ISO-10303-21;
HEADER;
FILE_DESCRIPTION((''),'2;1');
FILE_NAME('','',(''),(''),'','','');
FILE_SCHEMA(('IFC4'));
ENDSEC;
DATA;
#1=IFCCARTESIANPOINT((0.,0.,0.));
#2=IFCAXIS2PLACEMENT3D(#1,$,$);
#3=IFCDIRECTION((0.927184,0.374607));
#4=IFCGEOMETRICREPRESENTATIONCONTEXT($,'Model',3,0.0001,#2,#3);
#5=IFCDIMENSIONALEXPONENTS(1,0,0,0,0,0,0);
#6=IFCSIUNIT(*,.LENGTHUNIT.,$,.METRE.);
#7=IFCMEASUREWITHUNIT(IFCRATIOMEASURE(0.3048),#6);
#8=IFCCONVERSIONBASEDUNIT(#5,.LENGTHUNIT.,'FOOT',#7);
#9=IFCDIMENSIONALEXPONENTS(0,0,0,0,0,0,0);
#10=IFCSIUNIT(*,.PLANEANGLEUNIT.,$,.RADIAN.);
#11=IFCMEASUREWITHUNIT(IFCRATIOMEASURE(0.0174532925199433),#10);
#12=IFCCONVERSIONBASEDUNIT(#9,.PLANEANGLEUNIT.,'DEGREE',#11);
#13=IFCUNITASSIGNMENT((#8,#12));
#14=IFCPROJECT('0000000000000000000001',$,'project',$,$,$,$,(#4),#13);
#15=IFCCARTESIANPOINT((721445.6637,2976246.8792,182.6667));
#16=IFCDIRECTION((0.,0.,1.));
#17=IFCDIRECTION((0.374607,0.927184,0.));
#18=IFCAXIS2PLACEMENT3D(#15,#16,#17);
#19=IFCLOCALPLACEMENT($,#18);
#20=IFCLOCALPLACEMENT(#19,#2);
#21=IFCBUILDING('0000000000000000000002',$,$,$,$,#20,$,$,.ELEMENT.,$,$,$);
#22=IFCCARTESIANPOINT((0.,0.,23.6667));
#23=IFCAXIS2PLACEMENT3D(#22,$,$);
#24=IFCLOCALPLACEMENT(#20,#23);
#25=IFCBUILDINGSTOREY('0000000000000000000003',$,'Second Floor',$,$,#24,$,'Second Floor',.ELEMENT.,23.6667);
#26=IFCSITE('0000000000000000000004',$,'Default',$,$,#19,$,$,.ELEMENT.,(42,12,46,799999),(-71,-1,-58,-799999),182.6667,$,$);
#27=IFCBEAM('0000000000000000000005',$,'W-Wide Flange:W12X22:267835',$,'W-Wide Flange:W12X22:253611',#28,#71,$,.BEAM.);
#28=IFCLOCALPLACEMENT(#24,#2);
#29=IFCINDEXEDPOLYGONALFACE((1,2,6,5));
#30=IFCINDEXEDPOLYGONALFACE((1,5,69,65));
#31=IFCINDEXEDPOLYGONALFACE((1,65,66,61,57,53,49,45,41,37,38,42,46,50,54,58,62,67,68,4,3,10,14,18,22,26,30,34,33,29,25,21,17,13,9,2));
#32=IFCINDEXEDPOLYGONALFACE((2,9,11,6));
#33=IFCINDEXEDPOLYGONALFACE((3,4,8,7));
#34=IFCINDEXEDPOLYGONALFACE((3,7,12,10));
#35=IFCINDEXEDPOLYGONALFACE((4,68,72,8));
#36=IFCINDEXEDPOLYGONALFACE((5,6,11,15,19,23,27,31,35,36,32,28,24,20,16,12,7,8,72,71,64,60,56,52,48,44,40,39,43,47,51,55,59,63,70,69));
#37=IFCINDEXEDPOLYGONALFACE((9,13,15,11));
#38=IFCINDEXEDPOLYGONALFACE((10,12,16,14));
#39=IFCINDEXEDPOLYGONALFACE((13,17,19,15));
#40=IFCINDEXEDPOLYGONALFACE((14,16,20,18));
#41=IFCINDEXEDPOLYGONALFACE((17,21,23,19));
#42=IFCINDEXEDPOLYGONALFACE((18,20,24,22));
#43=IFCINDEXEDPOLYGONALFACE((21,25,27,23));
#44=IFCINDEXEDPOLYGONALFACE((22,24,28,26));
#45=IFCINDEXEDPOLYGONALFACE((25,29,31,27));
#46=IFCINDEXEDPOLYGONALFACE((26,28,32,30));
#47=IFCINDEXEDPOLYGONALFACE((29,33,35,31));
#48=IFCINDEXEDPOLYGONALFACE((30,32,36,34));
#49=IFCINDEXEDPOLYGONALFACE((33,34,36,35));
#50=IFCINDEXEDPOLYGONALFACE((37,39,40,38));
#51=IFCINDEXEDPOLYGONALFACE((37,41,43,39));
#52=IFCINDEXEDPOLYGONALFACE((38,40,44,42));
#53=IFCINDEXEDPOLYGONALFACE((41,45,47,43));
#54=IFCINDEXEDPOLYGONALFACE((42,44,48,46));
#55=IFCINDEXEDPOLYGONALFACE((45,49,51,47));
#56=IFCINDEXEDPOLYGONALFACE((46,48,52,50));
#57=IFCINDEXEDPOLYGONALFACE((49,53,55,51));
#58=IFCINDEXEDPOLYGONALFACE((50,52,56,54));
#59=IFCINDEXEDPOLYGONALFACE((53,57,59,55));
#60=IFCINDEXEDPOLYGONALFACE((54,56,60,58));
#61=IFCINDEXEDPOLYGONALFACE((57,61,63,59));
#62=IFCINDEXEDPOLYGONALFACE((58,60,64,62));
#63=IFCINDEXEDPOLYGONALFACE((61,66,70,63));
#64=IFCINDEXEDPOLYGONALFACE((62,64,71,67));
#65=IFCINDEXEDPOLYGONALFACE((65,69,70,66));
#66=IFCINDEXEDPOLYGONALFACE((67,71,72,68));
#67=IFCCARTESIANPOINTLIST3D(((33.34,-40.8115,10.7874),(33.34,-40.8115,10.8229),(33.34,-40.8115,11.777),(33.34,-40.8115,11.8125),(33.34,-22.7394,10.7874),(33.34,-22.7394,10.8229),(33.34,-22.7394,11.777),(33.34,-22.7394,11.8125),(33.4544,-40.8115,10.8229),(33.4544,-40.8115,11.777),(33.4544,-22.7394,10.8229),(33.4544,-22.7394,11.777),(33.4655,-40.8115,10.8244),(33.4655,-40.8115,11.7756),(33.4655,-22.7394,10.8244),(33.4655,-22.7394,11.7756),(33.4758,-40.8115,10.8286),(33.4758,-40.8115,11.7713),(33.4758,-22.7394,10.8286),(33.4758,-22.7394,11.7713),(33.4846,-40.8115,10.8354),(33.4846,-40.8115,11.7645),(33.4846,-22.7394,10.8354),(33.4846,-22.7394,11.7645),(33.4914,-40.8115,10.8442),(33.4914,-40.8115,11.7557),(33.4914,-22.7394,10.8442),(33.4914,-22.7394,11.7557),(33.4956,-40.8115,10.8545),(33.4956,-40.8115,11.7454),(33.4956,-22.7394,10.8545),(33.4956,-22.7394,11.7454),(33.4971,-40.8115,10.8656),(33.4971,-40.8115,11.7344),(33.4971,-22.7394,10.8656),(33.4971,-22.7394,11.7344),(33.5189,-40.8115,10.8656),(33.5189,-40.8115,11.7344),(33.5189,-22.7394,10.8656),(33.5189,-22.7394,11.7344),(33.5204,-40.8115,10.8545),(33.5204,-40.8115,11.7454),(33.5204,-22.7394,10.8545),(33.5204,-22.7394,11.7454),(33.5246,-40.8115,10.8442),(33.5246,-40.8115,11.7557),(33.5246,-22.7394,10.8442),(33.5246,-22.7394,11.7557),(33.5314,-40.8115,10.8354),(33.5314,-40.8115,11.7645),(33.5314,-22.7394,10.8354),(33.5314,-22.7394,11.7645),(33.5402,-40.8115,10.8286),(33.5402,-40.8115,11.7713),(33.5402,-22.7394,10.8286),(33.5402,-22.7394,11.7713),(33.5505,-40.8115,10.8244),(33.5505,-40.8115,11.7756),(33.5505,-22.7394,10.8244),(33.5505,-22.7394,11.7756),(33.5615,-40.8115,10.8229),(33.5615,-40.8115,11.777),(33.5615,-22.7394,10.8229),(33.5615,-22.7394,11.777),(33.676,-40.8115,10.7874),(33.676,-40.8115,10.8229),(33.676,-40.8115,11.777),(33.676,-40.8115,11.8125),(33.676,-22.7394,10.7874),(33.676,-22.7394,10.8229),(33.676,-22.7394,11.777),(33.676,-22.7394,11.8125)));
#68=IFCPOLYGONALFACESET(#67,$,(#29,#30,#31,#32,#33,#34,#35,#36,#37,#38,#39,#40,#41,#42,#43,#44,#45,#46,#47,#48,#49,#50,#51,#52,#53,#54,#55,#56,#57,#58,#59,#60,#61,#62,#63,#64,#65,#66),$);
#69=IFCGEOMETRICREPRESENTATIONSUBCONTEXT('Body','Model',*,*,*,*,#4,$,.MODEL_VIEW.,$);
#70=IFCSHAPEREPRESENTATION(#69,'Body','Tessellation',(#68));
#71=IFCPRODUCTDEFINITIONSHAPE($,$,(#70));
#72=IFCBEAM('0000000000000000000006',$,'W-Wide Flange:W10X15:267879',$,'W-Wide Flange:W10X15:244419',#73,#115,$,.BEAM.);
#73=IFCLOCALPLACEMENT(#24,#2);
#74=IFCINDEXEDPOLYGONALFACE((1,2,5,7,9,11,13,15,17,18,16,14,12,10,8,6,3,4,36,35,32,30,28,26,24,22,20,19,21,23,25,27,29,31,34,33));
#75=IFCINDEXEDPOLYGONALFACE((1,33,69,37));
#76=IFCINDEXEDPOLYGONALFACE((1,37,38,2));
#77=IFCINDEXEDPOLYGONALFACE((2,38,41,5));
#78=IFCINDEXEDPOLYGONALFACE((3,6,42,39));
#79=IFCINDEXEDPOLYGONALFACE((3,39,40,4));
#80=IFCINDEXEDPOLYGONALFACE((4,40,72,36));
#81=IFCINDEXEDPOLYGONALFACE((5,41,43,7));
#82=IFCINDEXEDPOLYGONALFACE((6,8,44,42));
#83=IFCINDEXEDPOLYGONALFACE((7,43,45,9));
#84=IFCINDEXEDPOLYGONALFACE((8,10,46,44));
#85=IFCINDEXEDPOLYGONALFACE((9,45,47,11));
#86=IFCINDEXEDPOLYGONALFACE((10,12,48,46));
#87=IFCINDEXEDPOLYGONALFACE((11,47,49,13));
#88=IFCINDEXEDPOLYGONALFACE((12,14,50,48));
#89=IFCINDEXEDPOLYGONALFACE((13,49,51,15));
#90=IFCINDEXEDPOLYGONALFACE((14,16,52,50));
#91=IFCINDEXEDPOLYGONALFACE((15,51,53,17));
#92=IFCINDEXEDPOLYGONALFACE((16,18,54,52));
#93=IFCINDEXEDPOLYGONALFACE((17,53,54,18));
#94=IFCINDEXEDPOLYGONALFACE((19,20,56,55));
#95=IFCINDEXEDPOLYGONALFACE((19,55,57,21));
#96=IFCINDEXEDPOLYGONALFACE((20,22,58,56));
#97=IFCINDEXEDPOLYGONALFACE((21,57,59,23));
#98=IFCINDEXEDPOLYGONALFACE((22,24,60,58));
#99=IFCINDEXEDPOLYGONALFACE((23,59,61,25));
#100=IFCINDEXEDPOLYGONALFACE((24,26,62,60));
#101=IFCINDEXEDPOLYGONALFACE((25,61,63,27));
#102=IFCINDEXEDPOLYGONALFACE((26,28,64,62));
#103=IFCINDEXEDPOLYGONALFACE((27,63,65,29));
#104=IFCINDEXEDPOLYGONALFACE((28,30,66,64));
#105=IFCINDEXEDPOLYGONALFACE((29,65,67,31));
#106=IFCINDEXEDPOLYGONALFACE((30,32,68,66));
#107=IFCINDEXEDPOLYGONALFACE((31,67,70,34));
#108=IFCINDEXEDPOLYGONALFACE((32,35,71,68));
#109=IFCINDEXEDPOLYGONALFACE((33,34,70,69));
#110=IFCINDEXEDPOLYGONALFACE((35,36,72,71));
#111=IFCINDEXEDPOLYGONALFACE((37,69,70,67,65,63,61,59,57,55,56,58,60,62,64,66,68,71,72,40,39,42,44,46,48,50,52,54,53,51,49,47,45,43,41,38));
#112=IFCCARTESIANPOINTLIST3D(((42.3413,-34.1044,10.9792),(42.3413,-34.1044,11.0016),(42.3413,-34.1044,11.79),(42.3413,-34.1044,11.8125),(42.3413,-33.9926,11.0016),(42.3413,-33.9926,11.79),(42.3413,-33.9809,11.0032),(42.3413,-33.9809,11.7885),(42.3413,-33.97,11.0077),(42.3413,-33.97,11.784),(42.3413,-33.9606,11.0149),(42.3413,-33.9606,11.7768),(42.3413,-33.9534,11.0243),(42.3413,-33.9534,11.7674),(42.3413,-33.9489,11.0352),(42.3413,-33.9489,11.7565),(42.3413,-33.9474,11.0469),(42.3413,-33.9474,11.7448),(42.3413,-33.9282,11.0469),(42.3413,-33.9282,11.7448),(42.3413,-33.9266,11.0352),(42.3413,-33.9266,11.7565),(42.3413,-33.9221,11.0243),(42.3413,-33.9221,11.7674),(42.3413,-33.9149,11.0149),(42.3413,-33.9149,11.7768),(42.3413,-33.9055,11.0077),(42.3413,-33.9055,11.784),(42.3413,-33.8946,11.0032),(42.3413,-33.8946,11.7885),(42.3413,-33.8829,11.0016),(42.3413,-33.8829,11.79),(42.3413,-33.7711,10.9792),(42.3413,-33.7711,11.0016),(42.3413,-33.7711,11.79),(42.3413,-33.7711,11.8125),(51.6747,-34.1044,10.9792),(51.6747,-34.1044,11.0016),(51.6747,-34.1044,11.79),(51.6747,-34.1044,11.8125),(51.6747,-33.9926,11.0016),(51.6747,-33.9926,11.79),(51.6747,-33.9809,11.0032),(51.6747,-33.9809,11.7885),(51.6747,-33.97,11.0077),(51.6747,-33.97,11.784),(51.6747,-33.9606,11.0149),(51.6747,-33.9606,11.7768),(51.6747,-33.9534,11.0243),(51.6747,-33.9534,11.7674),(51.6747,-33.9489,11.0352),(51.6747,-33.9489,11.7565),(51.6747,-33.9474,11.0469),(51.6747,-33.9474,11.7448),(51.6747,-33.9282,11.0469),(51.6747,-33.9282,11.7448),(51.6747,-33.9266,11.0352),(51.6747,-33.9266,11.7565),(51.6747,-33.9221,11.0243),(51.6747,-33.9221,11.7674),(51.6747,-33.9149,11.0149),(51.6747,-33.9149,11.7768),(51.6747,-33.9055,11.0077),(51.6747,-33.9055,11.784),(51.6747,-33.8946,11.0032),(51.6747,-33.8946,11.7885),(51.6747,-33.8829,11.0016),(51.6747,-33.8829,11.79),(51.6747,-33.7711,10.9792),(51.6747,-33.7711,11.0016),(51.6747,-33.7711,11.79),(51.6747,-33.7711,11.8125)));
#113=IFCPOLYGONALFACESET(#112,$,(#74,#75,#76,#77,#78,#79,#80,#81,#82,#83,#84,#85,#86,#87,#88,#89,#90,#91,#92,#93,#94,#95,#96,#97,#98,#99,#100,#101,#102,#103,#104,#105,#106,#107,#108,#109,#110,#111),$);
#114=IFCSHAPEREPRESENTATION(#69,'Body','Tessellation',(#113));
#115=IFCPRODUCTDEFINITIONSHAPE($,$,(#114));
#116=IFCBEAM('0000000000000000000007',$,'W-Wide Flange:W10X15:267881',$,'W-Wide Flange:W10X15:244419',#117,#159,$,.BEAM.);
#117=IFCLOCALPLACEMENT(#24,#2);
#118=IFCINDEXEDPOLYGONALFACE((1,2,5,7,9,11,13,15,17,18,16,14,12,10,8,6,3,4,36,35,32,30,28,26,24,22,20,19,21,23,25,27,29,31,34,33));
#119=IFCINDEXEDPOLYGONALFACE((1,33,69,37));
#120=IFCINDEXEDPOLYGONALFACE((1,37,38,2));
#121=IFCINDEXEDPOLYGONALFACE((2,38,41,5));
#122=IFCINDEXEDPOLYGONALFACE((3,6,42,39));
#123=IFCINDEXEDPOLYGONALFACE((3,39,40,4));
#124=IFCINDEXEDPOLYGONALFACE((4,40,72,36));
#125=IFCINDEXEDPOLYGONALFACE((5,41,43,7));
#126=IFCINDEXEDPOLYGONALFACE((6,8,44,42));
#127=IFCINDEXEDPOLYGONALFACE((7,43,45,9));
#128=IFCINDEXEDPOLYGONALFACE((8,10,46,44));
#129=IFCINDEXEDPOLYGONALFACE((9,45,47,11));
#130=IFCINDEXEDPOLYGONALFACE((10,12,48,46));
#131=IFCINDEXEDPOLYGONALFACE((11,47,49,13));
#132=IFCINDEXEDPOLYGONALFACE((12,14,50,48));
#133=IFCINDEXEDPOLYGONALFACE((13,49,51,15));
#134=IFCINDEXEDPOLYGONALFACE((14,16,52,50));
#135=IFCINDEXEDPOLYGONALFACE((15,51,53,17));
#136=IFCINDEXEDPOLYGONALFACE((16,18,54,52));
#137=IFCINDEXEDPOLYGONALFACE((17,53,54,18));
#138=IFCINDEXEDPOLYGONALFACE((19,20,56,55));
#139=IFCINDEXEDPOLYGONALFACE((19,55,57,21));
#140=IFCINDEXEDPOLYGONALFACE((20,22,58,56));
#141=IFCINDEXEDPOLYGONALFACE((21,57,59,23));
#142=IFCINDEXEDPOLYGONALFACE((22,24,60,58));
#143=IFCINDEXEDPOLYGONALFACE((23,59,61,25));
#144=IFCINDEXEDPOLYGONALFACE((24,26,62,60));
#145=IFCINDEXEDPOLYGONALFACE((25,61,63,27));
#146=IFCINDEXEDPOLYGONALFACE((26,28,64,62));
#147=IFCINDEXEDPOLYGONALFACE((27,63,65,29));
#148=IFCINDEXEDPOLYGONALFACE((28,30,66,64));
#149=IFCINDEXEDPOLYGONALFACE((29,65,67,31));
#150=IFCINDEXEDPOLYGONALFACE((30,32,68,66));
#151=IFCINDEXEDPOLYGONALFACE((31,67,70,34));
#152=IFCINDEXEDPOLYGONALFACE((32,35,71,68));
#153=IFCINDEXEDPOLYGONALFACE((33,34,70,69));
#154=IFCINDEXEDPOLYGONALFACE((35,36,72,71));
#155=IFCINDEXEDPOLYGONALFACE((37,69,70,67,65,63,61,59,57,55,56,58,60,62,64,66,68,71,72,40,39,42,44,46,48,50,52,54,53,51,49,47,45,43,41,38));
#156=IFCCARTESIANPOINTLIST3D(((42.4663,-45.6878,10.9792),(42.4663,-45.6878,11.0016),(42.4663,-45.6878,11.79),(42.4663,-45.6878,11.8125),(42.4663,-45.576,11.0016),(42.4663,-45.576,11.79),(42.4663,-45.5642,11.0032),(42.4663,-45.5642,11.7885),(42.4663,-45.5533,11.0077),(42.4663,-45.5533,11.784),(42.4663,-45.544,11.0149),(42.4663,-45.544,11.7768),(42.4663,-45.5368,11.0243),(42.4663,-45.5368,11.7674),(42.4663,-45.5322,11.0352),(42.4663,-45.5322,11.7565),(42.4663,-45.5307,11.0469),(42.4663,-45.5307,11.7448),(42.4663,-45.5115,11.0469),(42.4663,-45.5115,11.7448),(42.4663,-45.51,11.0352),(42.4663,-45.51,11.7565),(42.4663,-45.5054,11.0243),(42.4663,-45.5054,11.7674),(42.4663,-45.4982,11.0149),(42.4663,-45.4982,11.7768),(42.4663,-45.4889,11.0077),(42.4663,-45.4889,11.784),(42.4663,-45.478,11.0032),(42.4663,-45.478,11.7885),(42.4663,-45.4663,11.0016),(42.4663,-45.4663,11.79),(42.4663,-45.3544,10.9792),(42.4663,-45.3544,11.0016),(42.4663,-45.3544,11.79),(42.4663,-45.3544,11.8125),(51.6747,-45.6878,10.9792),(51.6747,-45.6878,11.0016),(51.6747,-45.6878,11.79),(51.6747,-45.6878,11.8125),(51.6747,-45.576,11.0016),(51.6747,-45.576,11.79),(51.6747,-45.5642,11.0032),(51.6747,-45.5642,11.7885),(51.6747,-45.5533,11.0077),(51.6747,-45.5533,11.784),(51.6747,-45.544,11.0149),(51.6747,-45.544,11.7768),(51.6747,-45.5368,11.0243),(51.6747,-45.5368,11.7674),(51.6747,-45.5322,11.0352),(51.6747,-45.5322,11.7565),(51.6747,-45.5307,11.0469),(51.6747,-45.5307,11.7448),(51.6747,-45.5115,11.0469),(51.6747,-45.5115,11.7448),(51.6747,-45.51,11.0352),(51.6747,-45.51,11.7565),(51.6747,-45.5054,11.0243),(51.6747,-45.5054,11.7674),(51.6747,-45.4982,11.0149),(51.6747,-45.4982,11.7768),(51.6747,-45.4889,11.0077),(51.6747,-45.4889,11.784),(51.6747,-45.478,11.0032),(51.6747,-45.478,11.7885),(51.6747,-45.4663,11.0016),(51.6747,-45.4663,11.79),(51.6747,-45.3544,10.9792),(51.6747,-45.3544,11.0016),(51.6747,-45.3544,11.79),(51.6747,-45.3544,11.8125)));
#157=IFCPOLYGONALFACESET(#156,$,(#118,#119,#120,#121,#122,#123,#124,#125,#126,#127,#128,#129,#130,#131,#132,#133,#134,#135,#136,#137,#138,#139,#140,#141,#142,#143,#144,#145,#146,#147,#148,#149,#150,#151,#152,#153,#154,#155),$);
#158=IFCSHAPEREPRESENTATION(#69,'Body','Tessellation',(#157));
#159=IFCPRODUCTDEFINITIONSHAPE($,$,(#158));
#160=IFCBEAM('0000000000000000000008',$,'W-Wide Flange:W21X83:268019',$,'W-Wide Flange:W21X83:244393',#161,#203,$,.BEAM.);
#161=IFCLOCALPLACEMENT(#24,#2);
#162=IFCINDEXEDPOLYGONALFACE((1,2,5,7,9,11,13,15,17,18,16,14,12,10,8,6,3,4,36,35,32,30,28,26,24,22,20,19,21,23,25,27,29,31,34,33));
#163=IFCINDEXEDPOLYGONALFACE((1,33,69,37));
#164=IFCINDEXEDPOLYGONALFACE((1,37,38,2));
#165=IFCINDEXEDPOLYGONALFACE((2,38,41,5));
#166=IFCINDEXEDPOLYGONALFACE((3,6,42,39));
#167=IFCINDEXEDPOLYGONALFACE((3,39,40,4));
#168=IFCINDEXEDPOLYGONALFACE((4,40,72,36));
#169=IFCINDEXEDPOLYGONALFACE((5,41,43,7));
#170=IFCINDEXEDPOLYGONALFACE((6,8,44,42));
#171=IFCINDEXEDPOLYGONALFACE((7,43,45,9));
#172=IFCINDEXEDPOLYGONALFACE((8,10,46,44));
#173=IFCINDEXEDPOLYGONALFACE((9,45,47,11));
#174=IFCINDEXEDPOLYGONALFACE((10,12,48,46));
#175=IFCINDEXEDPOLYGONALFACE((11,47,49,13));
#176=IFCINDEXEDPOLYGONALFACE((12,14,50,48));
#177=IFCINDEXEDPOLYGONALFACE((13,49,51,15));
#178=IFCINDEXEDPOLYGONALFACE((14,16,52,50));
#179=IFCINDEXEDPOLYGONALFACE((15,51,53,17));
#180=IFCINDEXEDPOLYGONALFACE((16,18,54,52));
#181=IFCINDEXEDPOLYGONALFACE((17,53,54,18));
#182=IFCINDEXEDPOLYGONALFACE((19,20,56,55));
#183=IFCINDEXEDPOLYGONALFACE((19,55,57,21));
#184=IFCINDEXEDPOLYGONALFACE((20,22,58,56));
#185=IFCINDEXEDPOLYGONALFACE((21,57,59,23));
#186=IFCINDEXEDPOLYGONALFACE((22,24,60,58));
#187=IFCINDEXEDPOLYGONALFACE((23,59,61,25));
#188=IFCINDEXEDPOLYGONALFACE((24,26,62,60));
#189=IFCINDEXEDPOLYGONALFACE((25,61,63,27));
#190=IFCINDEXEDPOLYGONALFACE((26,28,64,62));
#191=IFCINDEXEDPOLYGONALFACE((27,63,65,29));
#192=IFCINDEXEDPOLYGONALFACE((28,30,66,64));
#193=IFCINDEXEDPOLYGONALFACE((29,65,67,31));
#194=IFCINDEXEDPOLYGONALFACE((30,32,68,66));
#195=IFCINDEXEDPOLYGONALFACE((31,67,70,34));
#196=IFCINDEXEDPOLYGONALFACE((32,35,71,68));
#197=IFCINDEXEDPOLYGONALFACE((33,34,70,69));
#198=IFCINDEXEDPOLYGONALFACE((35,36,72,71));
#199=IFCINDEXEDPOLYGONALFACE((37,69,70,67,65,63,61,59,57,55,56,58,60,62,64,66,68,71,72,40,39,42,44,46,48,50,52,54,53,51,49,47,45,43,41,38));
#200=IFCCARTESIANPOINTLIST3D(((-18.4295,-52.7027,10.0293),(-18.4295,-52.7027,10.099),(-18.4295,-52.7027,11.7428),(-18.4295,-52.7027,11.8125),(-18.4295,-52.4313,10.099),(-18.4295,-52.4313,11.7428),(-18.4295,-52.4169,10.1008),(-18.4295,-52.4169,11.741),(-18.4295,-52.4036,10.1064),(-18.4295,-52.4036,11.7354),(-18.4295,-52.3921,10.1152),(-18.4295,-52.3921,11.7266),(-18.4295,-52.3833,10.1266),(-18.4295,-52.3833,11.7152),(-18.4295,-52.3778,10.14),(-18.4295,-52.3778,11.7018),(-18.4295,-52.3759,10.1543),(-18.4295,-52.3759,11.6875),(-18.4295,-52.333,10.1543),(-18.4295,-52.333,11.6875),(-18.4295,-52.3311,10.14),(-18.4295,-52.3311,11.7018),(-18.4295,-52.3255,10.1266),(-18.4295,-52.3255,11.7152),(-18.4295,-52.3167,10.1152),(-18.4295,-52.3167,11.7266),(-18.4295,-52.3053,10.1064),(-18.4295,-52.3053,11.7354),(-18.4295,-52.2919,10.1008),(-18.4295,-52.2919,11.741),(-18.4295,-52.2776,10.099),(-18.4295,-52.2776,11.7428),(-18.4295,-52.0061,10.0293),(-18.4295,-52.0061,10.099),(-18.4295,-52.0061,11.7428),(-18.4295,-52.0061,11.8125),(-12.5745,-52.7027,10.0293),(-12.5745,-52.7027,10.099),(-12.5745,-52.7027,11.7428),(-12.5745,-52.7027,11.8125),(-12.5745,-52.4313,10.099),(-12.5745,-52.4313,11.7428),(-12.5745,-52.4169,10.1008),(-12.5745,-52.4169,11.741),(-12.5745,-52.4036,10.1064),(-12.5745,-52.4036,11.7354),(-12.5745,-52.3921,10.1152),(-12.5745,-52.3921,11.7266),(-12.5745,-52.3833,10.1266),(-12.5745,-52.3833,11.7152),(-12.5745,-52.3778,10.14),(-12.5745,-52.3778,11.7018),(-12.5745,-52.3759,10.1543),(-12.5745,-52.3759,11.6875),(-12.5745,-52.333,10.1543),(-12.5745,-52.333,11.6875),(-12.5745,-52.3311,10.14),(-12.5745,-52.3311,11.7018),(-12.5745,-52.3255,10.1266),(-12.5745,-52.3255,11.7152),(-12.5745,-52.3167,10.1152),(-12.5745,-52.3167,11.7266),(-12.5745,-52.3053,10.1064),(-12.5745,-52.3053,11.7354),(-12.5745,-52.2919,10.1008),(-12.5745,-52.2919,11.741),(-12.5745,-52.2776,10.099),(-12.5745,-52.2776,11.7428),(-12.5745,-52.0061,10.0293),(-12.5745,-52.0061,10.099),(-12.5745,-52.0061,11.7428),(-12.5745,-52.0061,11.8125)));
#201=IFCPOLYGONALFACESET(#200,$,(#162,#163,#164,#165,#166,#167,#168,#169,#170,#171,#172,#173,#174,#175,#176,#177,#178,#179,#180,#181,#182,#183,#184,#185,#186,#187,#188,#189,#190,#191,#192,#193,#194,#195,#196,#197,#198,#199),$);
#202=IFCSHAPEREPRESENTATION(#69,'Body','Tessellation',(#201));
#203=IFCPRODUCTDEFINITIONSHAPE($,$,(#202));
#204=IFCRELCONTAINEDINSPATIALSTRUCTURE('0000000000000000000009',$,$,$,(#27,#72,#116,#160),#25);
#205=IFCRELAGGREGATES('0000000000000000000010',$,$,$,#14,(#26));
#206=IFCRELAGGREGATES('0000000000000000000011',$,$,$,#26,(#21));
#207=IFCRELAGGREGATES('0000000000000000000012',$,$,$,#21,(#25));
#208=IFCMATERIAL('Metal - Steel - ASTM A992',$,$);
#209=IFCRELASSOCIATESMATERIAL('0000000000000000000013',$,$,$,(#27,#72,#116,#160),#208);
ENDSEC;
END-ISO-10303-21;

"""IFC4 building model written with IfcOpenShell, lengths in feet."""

from ifc_helpers import new_model, entity, si_unit, converted_unit, direction, frame, frame_2d, origin, place, context, subcontext, project, spatial, i_section, extrude, material, element, save


model = new_model("IFC4")

# Units and contexts
model_context = context("Model", 3, precision=0.0001, world=origin(), true_north=direction((0.927184, 0.374607)))
body_context = subcontext(model_context, "Body", "Model", "MODEL_VIEW")
ifc_project = project(units=[converted_unit("LENGTHUNIT", "FOOT", entity("IfcRatioMeasure", 0.3048), si_unit("LENGTHUNIT", "METRE"), dimensions=[1, 0, 0, 0, 0, 0, 0]), converted_unit("PLANEANGLEUNIT", "DEGREE", entity("IfcRatioMeasure", 0.0174532925199433), si_unit("PLANEANGLEUNIT", "RADIAN"), dimensions=[0, 0, 0, 0, 0, 0, 0])], contexts=[model_context])

# Site, building, storey
site_placement = place(None, frame((721445.6637, 2976246.8792, 182.6667), z_axis=(0.0, 0.0, 1.0), x_axis=(0.374607, 0.927184, 0.0)))
site = spatial("IfcSite", under=ifc_project, at=site_placement, Name="Default", CompositionType="ELEMENT", RefLatitude=(42, 12, 46, 799999), RefLongitude=(-71, -1, -58, -799999), RefElevation=182.6667)
building_placement = place(site_placement, origin())
building = spatial("IfcBuilding", under=site, at=building_placement, CompositionType="ELEMENT")
storey_placement = place(building_placement, frame((0.0, 0.0, 23.6667)))
storey = spatial("IfcBuildingStorey", under=building, at=storey_placement, Name="Second Floor", LongName="Second Floor", CompositionType="ELEMENT", Elevation=23.6667)

# Shared definitions
ifc_material_1 = material(Name="Metal - Steel - ASTM A992")

# Beams
beam_1_placement = place(storey_placement, frame((33.508, -41.0211, 11.8125), z_axis=(0.0, 0.0, 1.0), x_axis=(0.0, 1.0, 0.0)))
element("IfcBeam", 1, at=beam_1_placement, inside=storey, material=ifc_material_1, Name="W-Wide Flange:W12X22:267835", ObjectType="W-Wide Flange:W12X22:253611", PredefinedType="BEAM", context=body_context, shape_type="SweptSolid", body=[
    extrude(i_section(OverallWidth=0.3359, OverallDepth=1.0251, WebThickness=0.0218, FlangeThickness=0.0355, FilletRadius=0.0426, at=frame_2d((0.0, 0.0), x_axis=(0.0, 1.0))), frame((0.2096, 0.0, -0.5125), z_axis=(1.0, 0.0, 0.0), x_axis=(0.0, 0.0, -1.0)), (0.0, 0.0, 1.0), 18.0721),
])
beam_2_placement = place(storey_placement, frame((42.008, -33.9378, 11.8125)))
element("IfcBeam", 2, at=beam_2_placement, inside=storey, material=ifc_material_1, Name="W-Wide Flange:W10X15:267879", ObjectType="W-Wide Flange:W10X15:244419", PredefinedType="BEAM", context=body_context, shape_type="SweptSolid", body=[
    extrude(i_section(OverallWidth=0.3333, OverallDepth=0.8333, WebThickness=0.0192, FlangeThickness=0.0225, FilletRadius=0.0452, at=frame_2d((0.0, 0.0), x_axis=(0.0, 1.0))), frame((0.3333, 0.0, -0.4167), z_axis=(1.0, 0.0, 0.0), x_axis=(0.0, 0.0, -1.0)), (0.0, 0.0, 1.0), 9.3333),
])
beam_3_placement = place(storey_placement, frame((42.008, -45.5211, 11.8125)))
element("IfcBeam", 3, at=beam_3_placement, inside=storey, material=ifc_material_1, Name="W-Wide Flange:W10X15:267881", ObjectType="W-Wide Flange:W10X15:244419", PredefinedType="BEAM", context=body_context, shape_type="SweptSolid", body=[
    extrude(i_section(OverallWidth=0.3333, OverallDepth=0.8333, WebThickness=0.0192, FlangeThickness=0.0225, FilletRadius=0.0452, at=frame_2d((0.0, 0.0), x_axis=(0.0, 1.0))), frame((0.4583, 0.0, -0.4167), z_axis=(1.0, 0.0, 0.0), x_axis=(0.0, 0.0, -1.0)), (0.0, 0.0, 1.0), 9.2083),
])
beam_4_placement = place(storey_placement, frame((-12.117, -52.3544, 11.8125), z_axis=(0.0, 0.0, 1.0), x_axis=(-1.0, 0.0, 0.0)))
element("IfcBeam", 4, at=beam_4_placement, inside=storey, material=ifc_material_1, Name="W-Wide Flange:W21X83:268019", ObjectType="W-Wide Flange:W21X83:244393", PredefinedType="BEAM", context=body_context, shape_type="SweptSolid", body=[
    extrude(i_section(OverallWidth=0.6966, OverallDepth=1.7832, WebThickness=0.043, FlangeThickness=0.0697, FilletRadius=0.0553, at=frame_2d((0.0, 0.0), x_axis=(0.0, 1.0))), frame((0.4575, 0.0, -0.8916), z_axis=(1.0, 0.0, 0.0), x_axis=(0.0, 0.0, -1.0)), (0.0, 0.0, 1.0), 5.855),
])

save(model, "model.ifc")
